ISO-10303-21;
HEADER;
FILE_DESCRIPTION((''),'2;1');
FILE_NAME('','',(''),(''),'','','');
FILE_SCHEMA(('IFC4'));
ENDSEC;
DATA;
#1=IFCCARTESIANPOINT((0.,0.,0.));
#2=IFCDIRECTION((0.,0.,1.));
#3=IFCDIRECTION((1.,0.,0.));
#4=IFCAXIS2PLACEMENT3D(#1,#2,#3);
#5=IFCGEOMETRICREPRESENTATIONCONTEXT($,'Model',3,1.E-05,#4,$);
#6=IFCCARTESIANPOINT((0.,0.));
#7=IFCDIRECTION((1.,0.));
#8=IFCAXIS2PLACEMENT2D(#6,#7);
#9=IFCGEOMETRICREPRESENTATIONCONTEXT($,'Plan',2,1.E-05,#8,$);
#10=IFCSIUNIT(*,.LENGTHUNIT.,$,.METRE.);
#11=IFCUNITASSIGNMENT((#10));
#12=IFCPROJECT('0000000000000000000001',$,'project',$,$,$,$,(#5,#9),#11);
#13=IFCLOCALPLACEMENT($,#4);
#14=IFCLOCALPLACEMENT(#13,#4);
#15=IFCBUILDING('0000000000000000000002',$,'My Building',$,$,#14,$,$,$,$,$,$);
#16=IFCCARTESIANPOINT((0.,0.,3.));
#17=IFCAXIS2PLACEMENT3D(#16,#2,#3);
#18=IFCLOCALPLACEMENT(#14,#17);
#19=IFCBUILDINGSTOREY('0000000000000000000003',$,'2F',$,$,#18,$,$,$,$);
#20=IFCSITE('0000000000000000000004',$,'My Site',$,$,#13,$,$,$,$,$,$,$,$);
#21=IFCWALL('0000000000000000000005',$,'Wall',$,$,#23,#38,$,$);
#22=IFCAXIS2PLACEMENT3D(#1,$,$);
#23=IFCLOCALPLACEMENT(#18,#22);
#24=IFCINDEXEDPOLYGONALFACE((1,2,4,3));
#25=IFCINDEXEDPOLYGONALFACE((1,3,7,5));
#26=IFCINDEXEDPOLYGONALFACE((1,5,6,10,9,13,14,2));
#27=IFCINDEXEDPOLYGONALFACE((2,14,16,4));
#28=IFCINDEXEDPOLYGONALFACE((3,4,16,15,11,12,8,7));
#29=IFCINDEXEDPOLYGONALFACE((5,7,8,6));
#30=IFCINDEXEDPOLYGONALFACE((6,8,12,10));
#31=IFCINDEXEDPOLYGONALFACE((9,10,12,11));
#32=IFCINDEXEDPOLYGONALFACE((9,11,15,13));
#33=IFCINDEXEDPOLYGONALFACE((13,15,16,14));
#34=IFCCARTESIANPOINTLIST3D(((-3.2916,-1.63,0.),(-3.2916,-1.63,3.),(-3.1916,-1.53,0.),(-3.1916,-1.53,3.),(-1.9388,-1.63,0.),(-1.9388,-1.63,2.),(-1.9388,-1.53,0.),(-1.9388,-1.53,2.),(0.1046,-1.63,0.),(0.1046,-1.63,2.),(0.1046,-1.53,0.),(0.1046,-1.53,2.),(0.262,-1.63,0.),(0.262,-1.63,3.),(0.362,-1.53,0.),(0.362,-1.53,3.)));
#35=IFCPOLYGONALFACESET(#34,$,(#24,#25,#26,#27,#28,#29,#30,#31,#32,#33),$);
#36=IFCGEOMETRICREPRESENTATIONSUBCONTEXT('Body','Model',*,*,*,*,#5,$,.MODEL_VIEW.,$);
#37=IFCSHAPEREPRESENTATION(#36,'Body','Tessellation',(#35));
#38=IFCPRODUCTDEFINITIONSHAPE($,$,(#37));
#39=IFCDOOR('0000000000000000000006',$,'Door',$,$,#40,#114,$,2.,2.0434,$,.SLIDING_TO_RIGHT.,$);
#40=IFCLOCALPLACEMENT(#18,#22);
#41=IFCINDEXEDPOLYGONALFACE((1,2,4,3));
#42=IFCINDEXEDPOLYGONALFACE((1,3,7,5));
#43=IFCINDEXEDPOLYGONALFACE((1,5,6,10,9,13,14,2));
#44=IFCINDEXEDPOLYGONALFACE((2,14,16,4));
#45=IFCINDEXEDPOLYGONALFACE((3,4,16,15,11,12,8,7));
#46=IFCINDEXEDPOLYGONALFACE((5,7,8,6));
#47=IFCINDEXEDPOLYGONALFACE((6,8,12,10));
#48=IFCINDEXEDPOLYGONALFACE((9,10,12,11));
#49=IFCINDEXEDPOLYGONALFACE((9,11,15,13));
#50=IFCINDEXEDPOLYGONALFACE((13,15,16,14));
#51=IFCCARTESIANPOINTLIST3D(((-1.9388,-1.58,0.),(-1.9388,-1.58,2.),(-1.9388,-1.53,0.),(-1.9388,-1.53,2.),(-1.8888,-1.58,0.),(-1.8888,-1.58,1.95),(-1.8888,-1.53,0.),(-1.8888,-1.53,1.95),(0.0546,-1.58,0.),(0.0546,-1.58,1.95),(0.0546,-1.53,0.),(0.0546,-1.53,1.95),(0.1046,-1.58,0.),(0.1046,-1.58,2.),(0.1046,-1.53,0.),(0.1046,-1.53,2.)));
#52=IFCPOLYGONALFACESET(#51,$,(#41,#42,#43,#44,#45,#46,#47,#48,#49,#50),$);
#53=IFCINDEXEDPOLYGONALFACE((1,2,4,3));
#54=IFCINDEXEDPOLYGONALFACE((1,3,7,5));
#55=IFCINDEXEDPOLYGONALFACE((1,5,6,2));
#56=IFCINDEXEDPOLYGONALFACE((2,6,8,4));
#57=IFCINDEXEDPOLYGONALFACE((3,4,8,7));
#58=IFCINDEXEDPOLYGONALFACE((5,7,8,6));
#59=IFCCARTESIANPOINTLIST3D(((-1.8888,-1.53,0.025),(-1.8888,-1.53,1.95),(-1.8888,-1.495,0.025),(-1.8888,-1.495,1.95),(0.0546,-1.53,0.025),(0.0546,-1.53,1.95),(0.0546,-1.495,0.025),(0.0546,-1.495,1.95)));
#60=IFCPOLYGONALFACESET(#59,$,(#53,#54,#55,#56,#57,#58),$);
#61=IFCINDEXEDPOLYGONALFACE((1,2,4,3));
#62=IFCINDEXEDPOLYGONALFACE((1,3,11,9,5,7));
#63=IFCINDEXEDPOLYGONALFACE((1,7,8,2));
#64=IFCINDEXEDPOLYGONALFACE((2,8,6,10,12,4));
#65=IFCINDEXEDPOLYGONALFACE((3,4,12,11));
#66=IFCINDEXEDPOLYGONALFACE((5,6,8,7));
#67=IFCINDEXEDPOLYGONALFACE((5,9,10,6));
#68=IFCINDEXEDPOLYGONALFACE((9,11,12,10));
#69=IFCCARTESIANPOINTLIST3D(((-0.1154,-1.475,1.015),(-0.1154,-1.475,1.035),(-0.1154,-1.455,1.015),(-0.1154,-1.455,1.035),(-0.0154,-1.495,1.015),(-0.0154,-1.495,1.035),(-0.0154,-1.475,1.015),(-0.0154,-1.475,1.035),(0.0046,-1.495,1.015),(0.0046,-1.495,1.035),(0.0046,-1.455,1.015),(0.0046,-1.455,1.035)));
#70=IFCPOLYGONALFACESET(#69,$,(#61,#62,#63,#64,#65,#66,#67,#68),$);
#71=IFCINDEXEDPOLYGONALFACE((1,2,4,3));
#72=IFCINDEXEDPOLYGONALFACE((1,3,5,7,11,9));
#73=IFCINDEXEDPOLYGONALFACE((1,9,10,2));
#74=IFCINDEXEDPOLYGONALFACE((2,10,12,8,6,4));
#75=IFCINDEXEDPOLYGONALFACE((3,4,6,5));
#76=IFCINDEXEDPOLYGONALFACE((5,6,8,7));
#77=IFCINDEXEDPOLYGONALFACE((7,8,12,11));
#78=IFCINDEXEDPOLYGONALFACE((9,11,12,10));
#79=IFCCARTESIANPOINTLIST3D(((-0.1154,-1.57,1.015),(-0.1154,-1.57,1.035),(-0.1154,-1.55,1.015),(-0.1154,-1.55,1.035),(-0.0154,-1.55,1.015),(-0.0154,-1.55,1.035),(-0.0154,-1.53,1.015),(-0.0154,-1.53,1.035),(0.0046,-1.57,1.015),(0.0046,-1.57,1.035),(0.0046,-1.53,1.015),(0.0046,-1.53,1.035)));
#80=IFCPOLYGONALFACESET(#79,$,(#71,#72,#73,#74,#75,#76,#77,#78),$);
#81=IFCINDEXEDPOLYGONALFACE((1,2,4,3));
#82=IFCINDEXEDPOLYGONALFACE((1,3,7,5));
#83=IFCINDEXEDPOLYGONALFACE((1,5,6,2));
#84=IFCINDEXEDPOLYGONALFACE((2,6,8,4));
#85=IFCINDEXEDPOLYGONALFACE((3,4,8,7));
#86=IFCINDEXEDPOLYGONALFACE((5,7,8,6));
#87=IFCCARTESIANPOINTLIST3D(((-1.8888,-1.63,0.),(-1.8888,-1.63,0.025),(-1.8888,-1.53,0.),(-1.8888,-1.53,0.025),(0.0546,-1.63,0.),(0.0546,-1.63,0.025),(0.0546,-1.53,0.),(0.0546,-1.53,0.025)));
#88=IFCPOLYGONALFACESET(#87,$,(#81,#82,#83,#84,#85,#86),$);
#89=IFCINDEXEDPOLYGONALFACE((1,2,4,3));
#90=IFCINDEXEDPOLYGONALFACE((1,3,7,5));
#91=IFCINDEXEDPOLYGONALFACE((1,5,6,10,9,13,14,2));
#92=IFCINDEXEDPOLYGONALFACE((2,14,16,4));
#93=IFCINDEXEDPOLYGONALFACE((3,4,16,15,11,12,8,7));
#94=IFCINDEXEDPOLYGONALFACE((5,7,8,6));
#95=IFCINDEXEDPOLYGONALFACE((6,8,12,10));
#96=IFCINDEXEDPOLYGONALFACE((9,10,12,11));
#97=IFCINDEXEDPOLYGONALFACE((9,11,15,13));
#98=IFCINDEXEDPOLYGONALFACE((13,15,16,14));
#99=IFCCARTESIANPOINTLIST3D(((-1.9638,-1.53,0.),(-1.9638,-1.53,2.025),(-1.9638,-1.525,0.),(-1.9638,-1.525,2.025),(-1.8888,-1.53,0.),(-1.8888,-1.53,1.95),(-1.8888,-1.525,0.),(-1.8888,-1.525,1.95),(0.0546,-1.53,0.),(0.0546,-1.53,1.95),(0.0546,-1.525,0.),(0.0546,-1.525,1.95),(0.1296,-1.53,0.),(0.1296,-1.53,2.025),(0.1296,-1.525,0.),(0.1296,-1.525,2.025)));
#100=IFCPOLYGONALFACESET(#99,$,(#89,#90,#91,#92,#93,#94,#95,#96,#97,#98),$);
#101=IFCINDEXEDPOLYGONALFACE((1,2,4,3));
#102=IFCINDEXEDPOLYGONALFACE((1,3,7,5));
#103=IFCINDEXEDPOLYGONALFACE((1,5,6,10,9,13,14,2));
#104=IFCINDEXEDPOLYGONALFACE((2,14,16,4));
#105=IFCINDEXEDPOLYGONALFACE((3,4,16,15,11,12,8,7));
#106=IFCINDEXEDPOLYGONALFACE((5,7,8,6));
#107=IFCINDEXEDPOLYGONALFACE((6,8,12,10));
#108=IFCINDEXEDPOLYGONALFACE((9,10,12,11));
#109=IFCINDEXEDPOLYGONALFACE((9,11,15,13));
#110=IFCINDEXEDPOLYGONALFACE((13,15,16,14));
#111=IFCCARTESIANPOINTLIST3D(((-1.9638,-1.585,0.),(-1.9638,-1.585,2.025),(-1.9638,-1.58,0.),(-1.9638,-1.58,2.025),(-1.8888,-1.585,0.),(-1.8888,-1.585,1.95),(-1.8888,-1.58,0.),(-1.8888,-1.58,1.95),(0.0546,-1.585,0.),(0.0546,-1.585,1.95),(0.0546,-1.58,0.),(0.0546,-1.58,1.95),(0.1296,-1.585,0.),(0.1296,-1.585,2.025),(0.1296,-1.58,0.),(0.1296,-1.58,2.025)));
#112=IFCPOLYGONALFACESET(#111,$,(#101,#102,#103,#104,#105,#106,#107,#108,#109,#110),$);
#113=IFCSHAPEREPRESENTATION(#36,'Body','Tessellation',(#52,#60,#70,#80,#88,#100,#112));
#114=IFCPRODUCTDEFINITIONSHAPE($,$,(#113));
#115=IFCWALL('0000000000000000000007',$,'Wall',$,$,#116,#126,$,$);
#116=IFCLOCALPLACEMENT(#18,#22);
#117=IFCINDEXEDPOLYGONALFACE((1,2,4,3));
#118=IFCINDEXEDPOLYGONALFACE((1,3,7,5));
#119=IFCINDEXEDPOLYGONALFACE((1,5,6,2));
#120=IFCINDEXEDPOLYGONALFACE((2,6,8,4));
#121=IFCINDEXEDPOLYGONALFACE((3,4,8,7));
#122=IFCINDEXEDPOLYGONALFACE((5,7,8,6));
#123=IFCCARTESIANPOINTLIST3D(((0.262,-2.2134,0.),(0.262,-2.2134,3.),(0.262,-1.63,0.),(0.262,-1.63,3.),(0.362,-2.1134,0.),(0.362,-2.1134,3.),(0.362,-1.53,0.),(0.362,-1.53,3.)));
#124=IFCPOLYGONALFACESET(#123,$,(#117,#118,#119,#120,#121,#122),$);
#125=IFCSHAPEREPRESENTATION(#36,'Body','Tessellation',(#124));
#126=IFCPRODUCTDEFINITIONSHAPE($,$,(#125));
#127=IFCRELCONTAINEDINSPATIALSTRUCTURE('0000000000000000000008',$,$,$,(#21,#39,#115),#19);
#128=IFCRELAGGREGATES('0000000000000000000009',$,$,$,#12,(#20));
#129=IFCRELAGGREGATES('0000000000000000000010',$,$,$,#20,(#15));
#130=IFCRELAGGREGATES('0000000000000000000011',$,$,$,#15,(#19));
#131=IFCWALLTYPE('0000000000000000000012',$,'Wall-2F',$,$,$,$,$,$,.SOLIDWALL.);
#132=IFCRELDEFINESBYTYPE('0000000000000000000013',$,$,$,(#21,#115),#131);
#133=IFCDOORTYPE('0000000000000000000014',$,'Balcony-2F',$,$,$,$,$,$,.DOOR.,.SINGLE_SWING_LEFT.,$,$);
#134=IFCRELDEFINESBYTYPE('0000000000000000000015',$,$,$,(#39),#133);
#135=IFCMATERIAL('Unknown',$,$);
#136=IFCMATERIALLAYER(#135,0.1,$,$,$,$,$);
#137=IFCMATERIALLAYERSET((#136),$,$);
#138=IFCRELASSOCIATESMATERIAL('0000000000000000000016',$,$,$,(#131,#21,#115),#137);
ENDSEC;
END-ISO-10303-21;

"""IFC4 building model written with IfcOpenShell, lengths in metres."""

from ifc_helpers import new_model, entity, si_unit, frame, origin_with_axes, origin_2d_with_axis, place, context, subcontext, project, spatial, line, indexed_curve, outline, extrude, shape, source, transform, mapped, material, layer, layer_set, layer_usage, type_object, type_shapes, element, fill, save


model = new_model("IFC4")

# Units and contexts
model_context = context("Model", 3, precision=1e-05, world=origin_with_axes())
plan_context = context("Plan", 2, precision=1e-05, world=origin_2d_with_axis())
body_context_1 = subcontext(model_context, "Body", "Model", "MODEL_VIEW")
body_context_2 = subcontext(plan_context, "Body", "Plan", "PLAN_VIEW")
ifc_project = project(units=[si_unit("LENGTHUNIT", "METRE")], contexts=[model_context, plan_context])

# Site, building, storey
site_placement = place(None, origin_with_axes())
site = spatial("IfcSite", under=ifc_project, at=site_placement, Name="My Site")
building_placement = place(site_placement, origin_with_axes())
building = spatial("IfcBuilding", under=site, at=building_placement, Name="My Building")
storey_placement = place(building_placement, frame((0.0, 0.0, 3.0), z_axis=(0.0, 0.0, 1.0), x_axis=(1.0, 0.0, 0.0)))
storey = spatial("IfcBuildingStorey", under=building, at=storey_placement, Name="2F")

# Shared definitions
ifc_material = material(Name="Unknown")

# Shared definitions
ifc_layer_1 = layer(ifc_material, 0.1)
ifc_layer_set_1 = layer_set([ifc_layer_1])
wall_type = type_object("IfcWallType", Name="Wall-2F", PredefinedType="SOLIDWALL", material=ifc_layer_set_1)

# Wall, opening, door
ifc_layer_usage_1 = layer_usage(ifc_layer_set_1, "AXIS2", "POSITIVE", 0.0)
wall_1_placement = place(storey_placement, frame((-3.2916, -1.63, 0.0), z_axis=(0.0, 0.0, 1.0), x_axis=(1.0, 0.0, 0.0)))
wall_1 = element("IfcWall", 1, at=wall_1_placement, inside=storey, type_object=wall_type, material=ifc_layer_usage_1, Name="Wall", context=body_context_1, shape_type="SweptSolid", body=[
    extrude(outline(indexed_curve([(0.0, 0.0), (0.1, 0.1), (3.6537, 0.1), (3.5537, 0.0)], segments=[line(1, 2, 3, 4, 1)])), origin_with_axes(), (0.0, 0.0, 1.0), 3.0),
])
shared_shape_1 = source(origin_with_axes(), body_context_1, "Body", "SweptSolid", [
    extrude(outline(indexed_curve([(0.0, 0.0), (2.0434, 0.0), (2.0434, 2.0), (0.0, 2.0)], segments=[line(1, 2, 3, 4, 1)])), frame((0.0, -0.6, 0.0), z_axis=(0.0, -1.0, 0.0), x_axis=(1.0, 0.0, 0.0)), (0.0, 0.0, -1.0), 1.2),
])
opening_1_placement = place(wall_1_placement, frame((3.3963, 0.1, 0.0), z_axis=(0.0, 0.0, 1.0), x_axis=(-1.0, 0.0, 0.0)))
opening_1 = element("IfcOpeningElement", 2, at=opening_1_placement, cuts=wall_1, PredefinedType="OPENING", context=body_context_1, shape_type="MappedRepresentation", body=[
    mapped(shared_shape_1, transform((0.0, 0.0, 0.0), x_axis=(1.0, 0.0, 0.0), y_axis=(0.0, 1.0, 0.0), z_axis=(0.0, 0.0, 1.0), scale=1.0)),
])
door_type_1 = type_object("IfcDoorType", Name="Balcony-2F", OperationType="SINGLE_SWING_LEFT", PredefinedType="DOOR")
shared_shape_2 = source(origin_with_axes(), body_context_1, "Body", "SweptSolid", [
    extrude(outline(indexed_curve([(0.0, 0.0), (0.0, 2.0), (2.0434, 2.0), (2.0434, 0.0), (1.9934, 0.0), (1.9934, 1.95), (0.05, 1.95), (0.05, 0.0)], segments=[line(1, 2, 3, 4, 5, 6, 7, 8, 1)])), frame((0.0, 0.0, 0.0), z_axis=(0.0, -1.0, 0.0), x_axis=(1.0, 0.0, 0.0)), (0.0, 0.0, -1.0), 0.05),
    extrude(outline(indexed_curve([(0.0, 0.0), (1.9434, 0.0), (1.9434, 0.035), (0.0, 0.035)], segments=[line(1, 2, 3, 4, 1)])), frame((0.05, -0.035, 0.025), z_axis=(0.0, 0.0, 1.0), x_axis=(1.0, 0.0, 0.0)), (0.0, 0.0, 1.0), 1.925),
    extrude(outline(indexed_curve([(0.0, 0.0), (0.0, -0.04), (0.12, -0.04), (0.12, -0.02), (0.02, -0.02), (0.02, 0.0)], segments=[line(1, 2, 3, 4, 5, 6, 1)])), frame((0.1, -0.035, 1.015), z_axis=(0.0, 0.0, 1.0), x_axis=(1.0, 0.0, 0.0)), (0.0, 0.0, 1.0), 0.02),
    extrude(outline(indexed_curve([(0.0, 0.0), (0.0, 0.04), (0.12, 0.04), (0.12, 0.02), (0.02, 0.02), (0.02, 0.0)], segments=[line(1, 2, 3, 4, 5, 6, 1)])), frame((0.1, 0.0, 1.015), z_axis=(0.0, 0.0, 1.0), x_axis=(1.0, 0.0, 0.0)), (0.0, 0.0, 1.0), 0.02),
    extrude(outline(indexed_curve([(0.0, 0.0), (1.9434, 0.0), (1.9434, 0.1), (0.0, 0.1)], segments=[line(1, 2, 3, 4, 1)])), frame((0.05, 0.0, 0.0), z_axis=(0.0, 0.0, 1.0), x_axis=(1.0, 0.0, 0.0)), (0.0, 0.0, 1.0), 0.025),
    extrude(outline(indexed_curve([(0.0, 0.0), (0.0, 2.025), (2.0934, 2.025), (2.0934, 0.0), (2.0184, 0.0), (2.0184, 1.95), (0.075, 1.95), (0.075, 0.0)], segments=[line(1, 2, 3, 4, 5, 6, 7, 8, 1)])), frame((-0.025, -0.005, 0.0), z_axis=(0.0, -1.0, 0.0), x_axis=(1.0, 0.0, 0.0)), (0.0, 0.0, -1.0), 0.005),
    extrude(outline(indexed_curve([(0.0, 0.0), (0.0, 2.025), (2.0934, 2.025), (2.0934, 0.0), (2.0184, 0.0), (2.0184, 1.95), (0.075, 1.95), (0.075, 0.0)], segments=[line(1, 2, 3, 4, 5, 6, 7, 8, 1)])), frame((-0.025, 0.05, 0.0), z_axis=(0.0, -1.0, 0.0), x_axis=(1.0, 0.0, 0.0)), (0.0, 0.0, -1.0), 0.005),
])
shared_shape_3 = source(origin_with_axes(), body_context_2, "Body", "Curve2D", [
    entity("IfcIndexedPolyCurve", entity("IfcCartesianPointList2D", [[0.0, 0.0], [0.05, 0.0], [0.05, 0.05], [0.0, 0.05]]), [entity("IfcLineIndex", [1, 2, 3, 4, 1])]),
    entity("IfcIndexedPolyCurve", entity("IfcCartesianPointList2D", [[2.0434, 0.0], [1.9934, 0.0], [1.9934, 0.05], [2.0434, 0.05]]), [entity("IfcLineIndex", [1, 2, 3, 4, 1])]),
    entity("IfcIndexedPolyCurve", entity("IfcCartesianPointList2D", [[2.965, -0.035], [1.0217, -0.035], [1.0217, 0.0], [2.965, 0.0]]), [entity("IfcLineIndex", [1, 2, 3, 4, 1])]),
])
type_shapes(door_type_1, [shared_shape_2, shared_shape_3])
door_1_placement = place(opening_1_placement, frame((0.0, 0.0, 0.0), z_axis=(0.0, 0.0, 1.0), x_axis=(1.0, 0.0, 0.0)))
door_1 = element("IfcDoor", 3, at=door_1_placement, inside=storey, type_object=door_type_1, Name="Door", OperationType="SLIDING_TO_RIGHT", OverallHeight=2.0, OverallWidth=2.0434, shapes=[
    shape(body_context_1, "Body", "MappedRepresentation", [mapped(shared_shape_2, transform((0.0, 0.0, 0.0), x_axis=(1.0, 0.0, 0.0), y_axis=(0.0, 1.0, 0.0), z_axis=(0.0, 0.0, 1.0), scale=1.0))]),
    shape(body_context_2, "Body", "MappedRepresentation", [mapped(shared_shape_3, transform((0.0, 0.0, 0.0), x_axis=(1.0, 0.0, 0.0), y_axis=(0.0, 1.0, 0.0), z_axis=(0.0, 0.0, 1.0), scale=1.0))]),
])
fill(opening_1, door_1)

# Wall
ifc_layer_usage_2 = layer_usage(ifc_layer_set_1, "AXIS2", "POSITIVE", 0.0)
wall_2_placement = place(storey_placement, frame((0.262, -1.63, 0.0), z_axis=(0.0, 0.0, 1.0), x_axis=(0.000001, -1.0, 0.0)))
element("IfcWall", 4, at=wall_2_placement, inside=storey, type_object=wall_type, material=ifc_layer_usage_2, Name="Wall", context=body_context_1, shape_type="SweptSolid", body=[
    extrude(outline(indexed_curve([(0.0, 0.0), (-0.1, 0.1), (0.4834, 0.1), (0.5834, 0.0)], segments=[line(1, 2, 3, 4, 1)])), origin_with_axes(), (0.0, 0.0, 1.0), 3.0),
])

save(model, "model.ifc")
